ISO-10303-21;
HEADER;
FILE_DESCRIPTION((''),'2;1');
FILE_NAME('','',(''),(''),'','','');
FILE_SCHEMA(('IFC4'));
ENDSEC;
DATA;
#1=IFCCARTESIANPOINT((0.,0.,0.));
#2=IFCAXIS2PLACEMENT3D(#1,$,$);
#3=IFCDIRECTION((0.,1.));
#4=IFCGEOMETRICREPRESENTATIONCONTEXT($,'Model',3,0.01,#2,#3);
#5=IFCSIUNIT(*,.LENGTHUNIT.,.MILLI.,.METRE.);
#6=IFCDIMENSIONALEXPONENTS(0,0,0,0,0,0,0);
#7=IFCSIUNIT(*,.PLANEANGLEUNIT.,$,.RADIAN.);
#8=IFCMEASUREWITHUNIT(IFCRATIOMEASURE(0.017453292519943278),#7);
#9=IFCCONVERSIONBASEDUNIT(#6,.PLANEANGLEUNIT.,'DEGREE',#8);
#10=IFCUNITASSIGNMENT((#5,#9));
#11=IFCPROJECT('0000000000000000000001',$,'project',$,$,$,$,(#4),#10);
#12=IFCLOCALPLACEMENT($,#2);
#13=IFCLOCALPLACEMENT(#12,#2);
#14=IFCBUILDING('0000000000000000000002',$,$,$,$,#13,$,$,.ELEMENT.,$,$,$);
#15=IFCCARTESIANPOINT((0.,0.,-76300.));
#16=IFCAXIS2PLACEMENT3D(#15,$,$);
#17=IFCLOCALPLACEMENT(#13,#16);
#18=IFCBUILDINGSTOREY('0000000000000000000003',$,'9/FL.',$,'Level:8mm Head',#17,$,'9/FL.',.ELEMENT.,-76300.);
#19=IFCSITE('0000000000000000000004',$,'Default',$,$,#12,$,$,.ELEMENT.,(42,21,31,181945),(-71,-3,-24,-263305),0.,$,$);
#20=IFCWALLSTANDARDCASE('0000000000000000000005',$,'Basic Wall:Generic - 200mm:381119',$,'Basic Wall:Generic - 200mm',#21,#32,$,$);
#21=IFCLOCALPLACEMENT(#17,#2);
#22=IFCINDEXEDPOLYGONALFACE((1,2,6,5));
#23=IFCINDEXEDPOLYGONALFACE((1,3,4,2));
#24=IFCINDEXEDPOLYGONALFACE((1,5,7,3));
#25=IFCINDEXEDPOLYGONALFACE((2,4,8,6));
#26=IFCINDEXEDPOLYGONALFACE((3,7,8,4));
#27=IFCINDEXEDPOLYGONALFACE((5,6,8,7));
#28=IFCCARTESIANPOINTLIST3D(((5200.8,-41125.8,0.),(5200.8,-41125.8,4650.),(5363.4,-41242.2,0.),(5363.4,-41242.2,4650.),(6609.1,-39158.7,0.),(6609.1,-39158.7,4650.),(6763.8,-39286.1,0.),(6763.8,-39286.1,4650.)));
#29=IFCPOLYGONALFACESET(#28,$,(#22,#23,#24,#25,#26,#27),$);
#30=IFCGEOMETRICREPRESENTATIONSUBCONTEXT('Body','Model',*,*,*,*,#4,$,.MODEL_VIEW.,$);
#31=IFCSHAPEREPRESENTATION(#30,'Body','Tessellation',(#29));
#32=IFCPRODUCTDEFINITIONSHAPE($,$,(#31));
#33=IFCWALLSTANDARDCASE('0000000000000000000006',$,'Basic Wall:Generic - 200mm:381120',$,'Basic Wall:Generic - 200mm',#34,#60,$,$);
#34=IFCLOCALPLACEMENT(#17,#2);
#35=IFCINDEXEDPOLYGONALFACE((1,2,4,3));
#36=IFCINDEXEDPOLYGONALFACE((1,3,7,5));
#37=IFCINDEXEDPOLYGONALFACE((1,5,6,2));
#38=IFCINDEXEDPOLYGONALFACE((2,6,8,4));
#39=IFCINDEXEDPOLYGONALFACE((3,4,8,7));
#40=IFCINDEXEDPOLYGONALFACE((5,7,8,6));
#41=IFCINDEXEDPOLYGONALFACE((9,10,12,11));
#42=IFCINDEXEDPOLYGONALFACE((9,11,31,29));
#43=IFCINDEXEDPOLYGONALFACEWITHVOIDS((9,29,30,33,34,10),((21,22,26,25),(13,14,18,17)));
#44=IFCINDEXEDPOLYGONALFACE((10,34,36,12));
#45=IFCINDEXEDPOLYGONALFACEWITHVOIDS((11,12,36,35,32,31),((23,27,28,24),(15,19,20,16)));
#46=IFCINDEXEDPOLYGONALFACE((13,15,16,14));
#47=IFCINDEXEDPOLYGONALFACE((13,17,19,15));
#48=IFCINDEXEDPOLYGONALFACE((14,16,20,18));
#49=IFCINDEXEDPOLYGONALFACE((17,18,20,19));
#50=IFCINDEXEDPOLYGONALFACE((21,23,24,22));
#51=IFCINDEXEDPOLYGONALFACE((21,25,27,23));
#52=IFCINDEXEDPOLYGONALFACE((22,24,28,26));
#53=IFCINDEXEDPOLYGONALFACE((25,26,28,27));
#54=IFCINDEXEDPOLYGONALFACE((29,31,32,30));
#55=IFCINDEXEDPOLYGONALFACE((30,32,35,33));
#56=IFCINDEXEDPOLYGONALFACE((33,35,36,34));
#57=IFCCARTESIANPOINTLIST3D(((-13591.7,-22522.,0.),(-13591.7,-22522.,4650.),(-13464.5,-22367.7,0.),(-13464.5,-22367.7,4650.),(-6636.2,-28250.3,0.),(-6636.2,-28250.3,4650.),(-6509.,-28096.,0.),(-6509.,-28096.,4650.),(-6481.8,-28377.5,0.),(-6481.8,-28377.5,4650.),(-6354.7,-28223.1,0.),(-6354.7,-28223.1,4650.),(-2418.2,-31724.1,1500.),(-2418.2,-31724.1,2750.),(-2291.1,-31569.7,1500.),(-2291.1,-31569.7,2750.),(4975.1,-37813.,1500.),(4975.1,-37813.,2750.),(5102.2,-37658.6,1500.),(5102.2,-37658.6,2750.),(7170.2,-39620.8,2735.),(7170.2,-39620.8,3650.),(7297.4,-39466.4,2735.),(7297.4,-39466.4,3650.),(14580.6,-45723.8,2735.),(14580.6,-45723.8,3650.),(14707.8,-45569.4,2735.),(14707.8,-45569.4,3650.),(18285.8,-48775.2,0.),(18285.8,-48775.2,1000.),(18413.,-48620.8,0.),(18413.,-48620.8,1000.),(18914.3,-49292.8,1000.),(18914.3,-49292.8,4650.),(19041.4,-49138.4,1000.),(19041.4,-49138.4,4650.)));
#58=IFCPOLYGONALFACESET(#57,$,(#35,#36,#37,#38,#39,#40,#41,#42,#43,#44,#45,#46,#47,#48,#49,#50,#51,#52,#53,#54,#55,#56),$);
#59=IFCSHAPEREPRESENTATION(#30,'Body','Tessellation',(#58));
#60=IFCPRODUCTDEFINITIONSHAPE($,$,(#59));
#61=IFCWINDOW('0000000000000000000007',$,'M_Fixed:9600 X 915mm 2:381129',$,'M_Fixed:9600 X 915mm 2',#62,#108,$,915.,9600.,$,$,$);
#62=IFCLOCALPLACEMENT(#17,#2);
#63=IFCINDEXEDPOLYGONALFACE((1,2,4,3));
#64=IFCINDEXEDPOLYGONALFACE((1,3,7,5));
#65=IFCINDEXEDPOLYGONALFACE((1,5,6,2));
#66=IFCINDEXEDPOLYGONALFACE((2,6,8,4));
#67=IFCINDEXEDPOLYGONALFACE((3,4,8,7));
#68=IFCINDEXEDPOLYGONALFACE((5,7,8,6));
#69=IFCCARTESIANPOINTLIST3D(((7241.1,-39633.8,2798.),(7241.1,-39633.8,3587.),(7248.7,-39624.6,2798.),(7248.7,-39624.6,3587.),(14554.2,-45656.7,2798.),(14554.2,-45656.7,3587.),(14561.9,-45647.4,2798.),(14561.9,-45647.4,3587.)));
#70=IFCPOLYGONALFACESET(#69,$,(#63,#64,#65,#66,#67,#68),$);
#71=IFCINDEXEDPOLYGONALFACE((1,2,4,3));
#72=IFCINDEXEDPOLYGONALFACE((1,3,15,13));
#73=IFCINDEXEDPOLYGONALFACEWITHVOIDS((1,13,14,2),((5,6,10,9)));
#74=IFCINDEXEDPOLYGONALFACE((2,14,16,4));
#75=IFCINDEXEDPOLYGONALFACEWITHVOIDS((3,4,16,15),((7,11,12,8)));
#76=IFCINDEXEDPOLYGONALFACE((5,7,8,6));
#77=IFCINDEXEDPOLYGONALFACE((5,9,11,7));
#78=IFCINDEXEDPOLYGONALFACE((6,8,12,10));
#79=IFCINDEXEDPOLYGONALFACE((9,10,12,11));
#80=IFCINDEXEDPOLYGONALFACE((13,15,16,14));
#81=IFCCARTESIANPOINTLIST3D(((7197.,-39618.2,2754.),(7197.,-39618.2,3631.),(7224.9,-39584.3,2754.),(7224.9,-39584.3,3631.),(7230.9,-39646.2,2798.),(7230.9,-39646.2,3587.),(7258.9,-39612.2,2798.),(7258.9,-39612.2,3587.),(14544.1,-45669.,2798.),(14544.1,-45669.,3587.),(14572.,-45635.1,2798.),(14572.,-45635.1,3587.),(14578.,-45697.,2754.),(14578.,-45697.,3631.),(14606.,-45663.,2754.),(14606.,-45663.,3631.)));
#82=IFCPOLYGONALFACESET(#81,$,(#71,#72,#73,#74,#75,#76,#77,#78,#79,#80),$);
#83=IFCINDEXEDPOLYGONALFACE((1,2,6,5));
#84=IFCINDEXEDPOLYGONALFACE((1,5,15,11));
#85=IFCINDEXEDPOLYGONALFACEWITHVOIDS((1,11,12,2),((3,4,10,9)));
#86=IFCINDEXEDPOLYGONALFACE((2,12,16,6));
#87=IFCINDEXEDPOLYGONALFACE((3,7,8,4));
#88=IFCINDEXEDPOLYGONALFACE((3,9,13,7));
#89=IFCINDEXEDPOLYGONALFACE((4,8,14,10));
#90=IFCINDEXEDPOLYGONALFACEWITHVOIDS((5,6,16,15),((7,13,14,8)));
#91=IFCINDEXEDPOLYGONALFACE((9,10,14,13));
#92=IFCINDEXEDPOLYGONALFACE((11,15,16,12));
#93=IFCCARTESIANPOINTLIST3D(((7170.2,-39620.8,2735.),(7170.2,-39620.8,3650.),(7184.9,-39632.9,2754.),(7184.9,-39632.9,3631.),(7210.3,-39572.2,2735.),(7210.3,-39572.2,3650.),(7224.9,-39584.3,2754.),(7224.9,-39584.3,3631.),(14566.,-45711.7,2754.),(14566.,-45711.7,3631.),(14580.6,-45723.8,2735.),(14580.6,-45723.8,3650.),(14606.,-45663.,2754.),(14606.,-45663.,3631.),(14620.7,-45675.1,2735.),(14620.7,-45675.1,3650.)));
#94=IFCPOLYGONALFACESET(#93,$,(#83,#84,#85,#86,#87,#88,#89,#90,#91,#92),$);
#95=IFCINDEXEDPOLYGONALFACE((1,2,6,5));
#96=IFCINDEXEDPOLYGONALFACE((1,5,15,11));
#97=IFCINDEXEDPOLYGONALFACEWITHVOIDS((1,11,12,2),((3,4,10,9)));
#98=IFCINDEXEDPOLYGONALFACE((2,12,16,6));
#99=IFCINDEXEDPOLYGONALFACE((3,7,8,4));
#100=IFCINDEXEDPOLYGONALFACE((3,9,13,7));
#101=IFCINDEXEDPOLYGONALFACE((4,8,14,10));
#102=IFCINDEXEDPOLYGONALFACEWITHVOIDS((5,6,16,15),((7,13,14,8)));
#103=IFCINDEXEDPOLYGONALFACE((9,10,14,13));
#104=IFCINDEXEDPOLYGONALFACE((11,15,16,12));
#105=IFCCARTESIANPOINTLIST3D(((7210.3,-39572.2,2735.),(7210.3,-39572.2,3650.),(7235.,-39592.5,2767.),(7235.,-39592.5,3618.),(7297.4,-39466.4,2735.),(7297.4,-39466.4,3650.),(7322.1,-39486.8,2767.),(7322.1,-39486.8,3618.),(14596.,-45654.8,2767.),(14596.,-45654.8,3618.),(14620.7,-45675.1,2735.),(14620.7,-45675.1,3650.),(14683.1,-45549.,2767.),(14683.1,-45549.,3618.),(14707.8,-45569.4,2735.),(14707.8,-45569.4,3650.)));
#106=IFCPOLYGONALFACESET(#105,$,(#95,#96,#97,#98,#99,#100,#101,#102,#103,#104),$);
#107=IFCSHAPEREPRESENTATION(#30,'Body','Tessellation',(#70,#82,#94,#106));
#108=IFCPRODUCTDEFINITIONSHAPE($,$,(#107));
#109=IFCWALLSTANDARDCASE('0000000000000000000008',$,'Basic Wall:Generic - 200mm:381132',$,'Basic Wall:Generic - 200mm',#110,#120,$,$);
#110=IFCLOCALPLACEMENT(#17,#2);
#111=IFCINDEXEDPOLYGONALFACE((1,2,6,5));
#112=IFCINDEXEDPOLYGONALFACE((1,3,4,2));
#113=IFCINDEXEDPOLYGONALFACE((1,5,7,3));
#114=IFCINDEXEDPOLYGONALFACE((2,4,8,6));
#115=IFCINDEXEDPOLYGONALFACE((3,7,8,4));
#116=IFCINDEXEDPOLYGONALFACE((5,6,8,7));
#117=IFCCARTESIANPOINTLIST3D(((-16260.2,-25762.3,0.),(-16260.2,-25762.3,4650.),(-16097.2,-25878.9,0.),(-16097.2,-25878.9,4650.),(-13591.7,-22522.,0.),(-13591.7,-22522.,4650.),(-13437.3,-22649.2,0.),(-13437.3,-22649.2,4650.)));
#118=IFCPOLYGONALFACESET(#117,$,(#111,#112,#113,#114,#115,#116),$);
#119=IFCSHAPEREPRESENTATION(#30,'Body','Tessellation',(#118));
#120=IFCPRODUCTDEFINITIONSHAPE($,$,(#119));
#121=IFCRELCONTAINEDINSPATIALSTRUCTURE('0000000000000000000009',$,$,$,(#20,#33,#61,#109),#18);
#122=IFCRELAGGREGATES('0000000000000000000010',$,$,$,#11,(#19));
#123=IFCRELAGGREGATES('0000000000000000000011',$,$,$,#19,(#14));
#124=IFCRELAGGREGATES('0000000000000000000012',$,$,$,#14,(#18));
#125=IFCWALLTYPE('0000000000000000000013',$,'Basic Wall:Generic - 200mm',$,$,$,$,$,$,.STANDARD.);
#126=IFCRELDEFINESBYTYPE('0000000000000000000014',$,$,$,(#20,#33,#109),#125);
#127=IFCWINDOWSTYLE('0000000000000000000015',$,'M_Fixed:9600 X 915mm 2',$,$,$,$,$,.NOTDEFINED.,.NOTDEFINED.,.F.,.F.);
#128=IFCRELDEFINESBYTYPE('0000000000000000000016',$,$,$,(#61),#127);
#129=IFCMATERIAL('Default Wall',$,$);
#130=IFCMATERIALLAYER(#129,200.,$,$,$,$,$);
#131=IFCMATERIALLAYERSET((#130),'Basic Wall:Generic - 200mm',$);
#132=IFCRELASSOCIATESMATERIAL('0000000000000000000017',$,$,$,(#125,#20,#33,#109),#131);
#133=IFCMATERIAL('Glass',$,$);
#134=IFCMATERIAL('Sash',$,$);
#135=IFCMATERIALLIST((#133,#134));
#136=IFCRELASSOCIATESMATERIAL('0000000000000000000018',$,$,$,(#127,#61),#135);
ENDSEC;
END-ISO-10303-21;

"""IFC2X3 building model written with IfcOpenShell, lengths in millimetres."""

from ifc_helpers import new_model, entity, si_unit, converted_unit, direction, frame, frame_2d, origin, place, context, subcontext, project, spatial, polyline, rectangle, outline, extrude, source, transform, mapped, material, material_list, layer, layer_set, layer_usage, type_object, type_shapes, element, fill, save


model = new_model("IFC2X3")

# Units and contexts
model_context = context("Model", 3, precision=0.01, world=origin(), true_north=direction((0.0, 1.0)))
body_context = subcontext(model_context, "Body", "Model", "MODEL_VIEW")
ifc_project = project(units=[si_unit("LENGTHUNIT", "METRE", prefix="MILLI"), converted_unit("PLANEANGLEUNIT", "DEGREE", entity("IfcRatioMeasure", 0.017453292519943278), si_unit("PLANEANGLEUNIT", "RADIAN"), dimensions=[0, 0, 0, 0, 0, 0, 0])], contexts=[model_context])

# Site, building, storey
site_placement = place(None, origin())
site = spatial("IfcSite", under=ifc_project, at=site_placement, Name="Default", CompositionType="ELEMENT", RefLatitude=(42, 21, 31, 181945), RefLongitude=(-71, -3, -24, -263305), RefElevation=0.0)
building_placement = place(site_placement, origin())
building = spatial("IfcBuilding", under=site, at=building_placement, CompositionType="ELEMENT")
storey_placement = place(building_placement, frame((0.0, 0.0, -76300.0)))
storey = spatial("IfcBuildingStorey", under=building, at=storey_placement, Name="9/FL.", ObjectType="Level:8mm Head", LongName="9/FL.", CompositionType="ELEMENT", Elevation=-76300.0)

# Shared definitions
ifc_material_1 = material(Name="Default Wall")
ifc_layer = layer(ifc_material_1, 200.0)
ifc_layer_set = layer_set([ifc_layer], Name="Basic Wall:Generic - 200mm")
ifc_layer_usage = layer_usage(ifc_layer_set, "AXIS2", "NEGATIVE", 100.0)
wall_type = type_object("IfcWallType", Name="Basic Wall:Generic - 200mm", PredefinedType="STANDARD", material=ifc_layer_set)

# Shared definitions
ifc_material_2 = material(Name="Glass")
ifc_material_3 = material(Name="Sash")
ifc_material_list = material_list([ifc_material_2, ifc_material_3])

# Wall
wall_1_placement = place(storey_placement, frame((5282.1, -41184.0, 0.0), z_axis=(0.0, 0.0, 1.0), x_axis=(0.582098, 0.813119, 0.0)))
element("IfcWallStandardCase", 1, at=wall_1_placement, inside=storey, type_object=wall_type, material=ifc_layer_usage, Name="Basic Wall:Generic - 200mm:381119", ObjectType="Basic Wall:Generic - 200mm", context=body_context, shape_type="SweptSolid", body=[
    extrude(outline(polyline([(2405.7, -100.0), (2419.3, 100.0), (0.0, 100.0), (0.0, -100.0), (2405.7, -100.0)])), origin(), (0.0, 0.0, 1.0), 4650.0),
])

# Wall, openings, window
wall_2_placement = place(storey_placement, frame((-13528.1, -22444.8, 0.0), z_axis=(0.0, 0.0, 1.0), x_axis=(0.771917, -0.635723, 0.0)))
wall_2 = element("IfcWallStandardCase", 2, at=wall_2_placement, inside=storey, type_object=wall_type, material=ifc_layer_usage, Name="Basic Wall:Generic - 200mm:381120", ObjectType="Basic Wall:Generic - 200mm", context=body_context, shape_type="SweptSolid", body=[
    extrude(rectangle(XDim=42110.7, YDim=200.0, at=frame_2d((21055.3, 0.0), x_axis=(-1.0, 0.0))), origin(), (0.0, 0.0, 1.0), 4650.0),
])
opening_1_placement = place(storey_placement, frame((-13528.1, -22444.8, 0.0), z_axis=(0.0, 0.0, 1.0), x_axis=(0.771917, -0.635723, 0.0)))
element("IfcOpeningElement", 3, at=opening_1_placement, cuts=wall_2, ObjectType="Opening", context=body_context, shape_type="SweptSolid", body=[
    extrude(rectangle(XDim=4650.0, YDim=200.0, at=frame_2d((0.0, 0.0), x_axis=(1.0, 0.0))), frame((9210.7, 0.0, 2325.0), z_axis=(-1.0, 0.0, 0.0), x_axis=(0.0, 0.0, 1.0)), (0.0, 0.0, 1.0), 200.0),
])
opening_2_placement = place(wall_2_placement, origin())
element("IfcOpeningElement", 4, at=opening_2_placement, cuts=wall_2, ObjectType="Opening", context=body_context, shape_type="SweptSolid", body=[
    extrude(rectangle(XDim=1250.0, YDim=9577.8, at=frame_2d((0.0, 0.0), x_axis=(1.0, 0.0))), frame((19263.9, -100.0, 2125.0), z_axis=(0.0, 1.0, 0.0), x_axis=(0.0, 0.0, -1.0)), (0.0, 0.0, 1.0), 200.0),
])
opening_3_placement = place(wall_2_placement, frame((-3826.1, 25925.7, 0.0), z_axis=(0.0, 0.0, 1.0), x_axis=(0.771917, 0.635723, 0.0)))
element("IfcOpeningElement", 5, at=opening_3_placement, cuts=wall_2, ObjectType="Opening", context=body_context, shape_type="SweptSolid", body=[
    extrude(rectangle(XDim=1000.0, YDim=1010.1, at=frame_2d((0.0, 0.0), x_axis=(1.0, 0.0))), frame((18667.6, -49106.1, 500.0), z_axis=(0.635723, 0.771917, 0.0), x_axis=(0.0, 0.0, -1.0)), (0.0, 0.0, 1.0), 1012.7),
])
opening_4_placement = place(wall_2_placement, frame((36496.6, 100.0, 2735.0)))
opening_4 = element("IfcOpeningElement", 6, at=opening_4_placement, cuts=wall_2, ObjectType="Opening", context=body_context, shape_type="SweptSolid", body=[
    extrude(rectangle(XDim=915.0, YDim=9600.0, at=frame_2d((457.5, 4800.0), x_axis=(1.0, 0.0))), frame((0.0, 0.0, 0.0), z_axis=(0.0, -1.0, 0.0), x_axis=(0.0, 0.0, 1.0)), (0.0, 0.0, 1.0), 200.0),
])
window_style_1 = type_object("IfcWindowStyle", Name="M_Fixed:9600 X 915mm 2", ConstructionType="NOTDEFINED", OperationType="NOTDEFINED", ParameterTakesPrecedence=False, Sizeable=False, material=ifc_material_list)
shared_shape_1 = source(origin(), body_context, "Body", "SweptSolid", [
    extrude(rectangle(XDim=12.0, YDim=9474.0, at=frame_2d((0.0, 0.0), x_axis=(1.0, 0.0))), frame((4800.0, 159.0, 63.0), z_axis=(0.0, 0.0, 1.0), x_axis=(0.0, -1.0, 0.0)), (0.0, 0.0, 1.0), 789.0),
    extrude(outline(polyline([(-4781.0, -438.5), (4781.0, -438.5), (4781.0, 438.5), (-4781.0, 438.5), (-4781.0, -438.5)]), holes=[polyline([(-4737.0, -394.5), (-4737.0, 394.5), (4737.0, 394.5), (4737.0, -394.5), (-4737.0, -394.5)])]), frame((4800.0, 137.0, 457.5), z_axis=(0.0, 1.0, 0.0), x_axis=(1.0, 0.0, 0.0)), (0.0, 0.0, 1.0), 44.0),
    extrude(outline(polyline([(-4800.0, -457.5), (4800.0, -457.5), (4800.0, 457.5), (-4800.0, 457.5), (-4800.0, -457.5)]), holes=[polyline([(-4781.0, -438.5), (-4781.0, 438.5), (4781.0, 438.5), (4781.0, -438.5), (-4781.0, -438.5)])]), frame((4800.0, 137.0, 457.5), z_axis=(0.0, 1.0, 0.0), x_axis=(1.0, 0.0, 0.0)), (0.0, 0.0, 1.0), 63.0),
    extrude(outline(polyline([(-4800.0, -457.5), (4800.0, -457.5), (4800.0, 457.5), (-4800.0, 457.5), (-4800.0, -457.5)]), holes=[polyline([(-4768.0, -425.5), (-4768.0, 425.5), (4768.0, 425.5), (4768.0, -425.5), (-4768.0, -425.5)])]), frame((4800.0, 0.0, 457.5), z_axis=(0.0, 1.0, 0.0), x_axis=(1.0, 0.0, 0.0)), (0.0, 0.0, 1.0), 137.0),
])
type_shapes(window_style_1, [shared_shape_1])
window_1_placement = place(opening_4_placement, frame((0.0, 0.0, 0.0), z_axis=(0.0, 0.0, 1.0), x_axis=(-1.0, 0.0, 0.0)))
window_1 = element("IfcWindow", 7, at=window_1_placement, inside=storey, type_object=window_style_1, material=ifc_material_list, Name="M_Fixed:9600 X 915mm 2:381129", ObjectType="M_Fixed:9600 X 915mm 2", OverallHeight=915.0, OverallWidth=9600.0, context=body_context, shape_type="MappedRepresentation", body=[
    mapped(shared_shape_1, transform((0.0, 0.0, 0.0), scale=1.0)),
])
fill(opening_4, window_1)

# Wall
wall_3_placement = place(storey_placement, frame((-16183.0, -25825.8, 0.0), z_axis=(0.0, 0.0, 1.0), x_axis=(0.635723, 0.771917, 0.0)))
element("IfcWallStandardCase", 8, at=wall_3_placement, inside=storey, type_object=wall_type, material=ifc_layer_usage, Name="Basic Wall:Generic - 200mm:381132", ObjectType="Basic Wall:Generic - 200mm", context=body_context, shape_type="SweptSolid", body=[
    extrude(outline(polyline([(4197.6, -100.0), (4197.6, 100.0), (0.0, 100.0), (13.5, -100.0), (4197.6, -100.0)])), origin(), (0.0, 0.0, 1.0), 4650.0),
])

save(model, "model.ifc")
